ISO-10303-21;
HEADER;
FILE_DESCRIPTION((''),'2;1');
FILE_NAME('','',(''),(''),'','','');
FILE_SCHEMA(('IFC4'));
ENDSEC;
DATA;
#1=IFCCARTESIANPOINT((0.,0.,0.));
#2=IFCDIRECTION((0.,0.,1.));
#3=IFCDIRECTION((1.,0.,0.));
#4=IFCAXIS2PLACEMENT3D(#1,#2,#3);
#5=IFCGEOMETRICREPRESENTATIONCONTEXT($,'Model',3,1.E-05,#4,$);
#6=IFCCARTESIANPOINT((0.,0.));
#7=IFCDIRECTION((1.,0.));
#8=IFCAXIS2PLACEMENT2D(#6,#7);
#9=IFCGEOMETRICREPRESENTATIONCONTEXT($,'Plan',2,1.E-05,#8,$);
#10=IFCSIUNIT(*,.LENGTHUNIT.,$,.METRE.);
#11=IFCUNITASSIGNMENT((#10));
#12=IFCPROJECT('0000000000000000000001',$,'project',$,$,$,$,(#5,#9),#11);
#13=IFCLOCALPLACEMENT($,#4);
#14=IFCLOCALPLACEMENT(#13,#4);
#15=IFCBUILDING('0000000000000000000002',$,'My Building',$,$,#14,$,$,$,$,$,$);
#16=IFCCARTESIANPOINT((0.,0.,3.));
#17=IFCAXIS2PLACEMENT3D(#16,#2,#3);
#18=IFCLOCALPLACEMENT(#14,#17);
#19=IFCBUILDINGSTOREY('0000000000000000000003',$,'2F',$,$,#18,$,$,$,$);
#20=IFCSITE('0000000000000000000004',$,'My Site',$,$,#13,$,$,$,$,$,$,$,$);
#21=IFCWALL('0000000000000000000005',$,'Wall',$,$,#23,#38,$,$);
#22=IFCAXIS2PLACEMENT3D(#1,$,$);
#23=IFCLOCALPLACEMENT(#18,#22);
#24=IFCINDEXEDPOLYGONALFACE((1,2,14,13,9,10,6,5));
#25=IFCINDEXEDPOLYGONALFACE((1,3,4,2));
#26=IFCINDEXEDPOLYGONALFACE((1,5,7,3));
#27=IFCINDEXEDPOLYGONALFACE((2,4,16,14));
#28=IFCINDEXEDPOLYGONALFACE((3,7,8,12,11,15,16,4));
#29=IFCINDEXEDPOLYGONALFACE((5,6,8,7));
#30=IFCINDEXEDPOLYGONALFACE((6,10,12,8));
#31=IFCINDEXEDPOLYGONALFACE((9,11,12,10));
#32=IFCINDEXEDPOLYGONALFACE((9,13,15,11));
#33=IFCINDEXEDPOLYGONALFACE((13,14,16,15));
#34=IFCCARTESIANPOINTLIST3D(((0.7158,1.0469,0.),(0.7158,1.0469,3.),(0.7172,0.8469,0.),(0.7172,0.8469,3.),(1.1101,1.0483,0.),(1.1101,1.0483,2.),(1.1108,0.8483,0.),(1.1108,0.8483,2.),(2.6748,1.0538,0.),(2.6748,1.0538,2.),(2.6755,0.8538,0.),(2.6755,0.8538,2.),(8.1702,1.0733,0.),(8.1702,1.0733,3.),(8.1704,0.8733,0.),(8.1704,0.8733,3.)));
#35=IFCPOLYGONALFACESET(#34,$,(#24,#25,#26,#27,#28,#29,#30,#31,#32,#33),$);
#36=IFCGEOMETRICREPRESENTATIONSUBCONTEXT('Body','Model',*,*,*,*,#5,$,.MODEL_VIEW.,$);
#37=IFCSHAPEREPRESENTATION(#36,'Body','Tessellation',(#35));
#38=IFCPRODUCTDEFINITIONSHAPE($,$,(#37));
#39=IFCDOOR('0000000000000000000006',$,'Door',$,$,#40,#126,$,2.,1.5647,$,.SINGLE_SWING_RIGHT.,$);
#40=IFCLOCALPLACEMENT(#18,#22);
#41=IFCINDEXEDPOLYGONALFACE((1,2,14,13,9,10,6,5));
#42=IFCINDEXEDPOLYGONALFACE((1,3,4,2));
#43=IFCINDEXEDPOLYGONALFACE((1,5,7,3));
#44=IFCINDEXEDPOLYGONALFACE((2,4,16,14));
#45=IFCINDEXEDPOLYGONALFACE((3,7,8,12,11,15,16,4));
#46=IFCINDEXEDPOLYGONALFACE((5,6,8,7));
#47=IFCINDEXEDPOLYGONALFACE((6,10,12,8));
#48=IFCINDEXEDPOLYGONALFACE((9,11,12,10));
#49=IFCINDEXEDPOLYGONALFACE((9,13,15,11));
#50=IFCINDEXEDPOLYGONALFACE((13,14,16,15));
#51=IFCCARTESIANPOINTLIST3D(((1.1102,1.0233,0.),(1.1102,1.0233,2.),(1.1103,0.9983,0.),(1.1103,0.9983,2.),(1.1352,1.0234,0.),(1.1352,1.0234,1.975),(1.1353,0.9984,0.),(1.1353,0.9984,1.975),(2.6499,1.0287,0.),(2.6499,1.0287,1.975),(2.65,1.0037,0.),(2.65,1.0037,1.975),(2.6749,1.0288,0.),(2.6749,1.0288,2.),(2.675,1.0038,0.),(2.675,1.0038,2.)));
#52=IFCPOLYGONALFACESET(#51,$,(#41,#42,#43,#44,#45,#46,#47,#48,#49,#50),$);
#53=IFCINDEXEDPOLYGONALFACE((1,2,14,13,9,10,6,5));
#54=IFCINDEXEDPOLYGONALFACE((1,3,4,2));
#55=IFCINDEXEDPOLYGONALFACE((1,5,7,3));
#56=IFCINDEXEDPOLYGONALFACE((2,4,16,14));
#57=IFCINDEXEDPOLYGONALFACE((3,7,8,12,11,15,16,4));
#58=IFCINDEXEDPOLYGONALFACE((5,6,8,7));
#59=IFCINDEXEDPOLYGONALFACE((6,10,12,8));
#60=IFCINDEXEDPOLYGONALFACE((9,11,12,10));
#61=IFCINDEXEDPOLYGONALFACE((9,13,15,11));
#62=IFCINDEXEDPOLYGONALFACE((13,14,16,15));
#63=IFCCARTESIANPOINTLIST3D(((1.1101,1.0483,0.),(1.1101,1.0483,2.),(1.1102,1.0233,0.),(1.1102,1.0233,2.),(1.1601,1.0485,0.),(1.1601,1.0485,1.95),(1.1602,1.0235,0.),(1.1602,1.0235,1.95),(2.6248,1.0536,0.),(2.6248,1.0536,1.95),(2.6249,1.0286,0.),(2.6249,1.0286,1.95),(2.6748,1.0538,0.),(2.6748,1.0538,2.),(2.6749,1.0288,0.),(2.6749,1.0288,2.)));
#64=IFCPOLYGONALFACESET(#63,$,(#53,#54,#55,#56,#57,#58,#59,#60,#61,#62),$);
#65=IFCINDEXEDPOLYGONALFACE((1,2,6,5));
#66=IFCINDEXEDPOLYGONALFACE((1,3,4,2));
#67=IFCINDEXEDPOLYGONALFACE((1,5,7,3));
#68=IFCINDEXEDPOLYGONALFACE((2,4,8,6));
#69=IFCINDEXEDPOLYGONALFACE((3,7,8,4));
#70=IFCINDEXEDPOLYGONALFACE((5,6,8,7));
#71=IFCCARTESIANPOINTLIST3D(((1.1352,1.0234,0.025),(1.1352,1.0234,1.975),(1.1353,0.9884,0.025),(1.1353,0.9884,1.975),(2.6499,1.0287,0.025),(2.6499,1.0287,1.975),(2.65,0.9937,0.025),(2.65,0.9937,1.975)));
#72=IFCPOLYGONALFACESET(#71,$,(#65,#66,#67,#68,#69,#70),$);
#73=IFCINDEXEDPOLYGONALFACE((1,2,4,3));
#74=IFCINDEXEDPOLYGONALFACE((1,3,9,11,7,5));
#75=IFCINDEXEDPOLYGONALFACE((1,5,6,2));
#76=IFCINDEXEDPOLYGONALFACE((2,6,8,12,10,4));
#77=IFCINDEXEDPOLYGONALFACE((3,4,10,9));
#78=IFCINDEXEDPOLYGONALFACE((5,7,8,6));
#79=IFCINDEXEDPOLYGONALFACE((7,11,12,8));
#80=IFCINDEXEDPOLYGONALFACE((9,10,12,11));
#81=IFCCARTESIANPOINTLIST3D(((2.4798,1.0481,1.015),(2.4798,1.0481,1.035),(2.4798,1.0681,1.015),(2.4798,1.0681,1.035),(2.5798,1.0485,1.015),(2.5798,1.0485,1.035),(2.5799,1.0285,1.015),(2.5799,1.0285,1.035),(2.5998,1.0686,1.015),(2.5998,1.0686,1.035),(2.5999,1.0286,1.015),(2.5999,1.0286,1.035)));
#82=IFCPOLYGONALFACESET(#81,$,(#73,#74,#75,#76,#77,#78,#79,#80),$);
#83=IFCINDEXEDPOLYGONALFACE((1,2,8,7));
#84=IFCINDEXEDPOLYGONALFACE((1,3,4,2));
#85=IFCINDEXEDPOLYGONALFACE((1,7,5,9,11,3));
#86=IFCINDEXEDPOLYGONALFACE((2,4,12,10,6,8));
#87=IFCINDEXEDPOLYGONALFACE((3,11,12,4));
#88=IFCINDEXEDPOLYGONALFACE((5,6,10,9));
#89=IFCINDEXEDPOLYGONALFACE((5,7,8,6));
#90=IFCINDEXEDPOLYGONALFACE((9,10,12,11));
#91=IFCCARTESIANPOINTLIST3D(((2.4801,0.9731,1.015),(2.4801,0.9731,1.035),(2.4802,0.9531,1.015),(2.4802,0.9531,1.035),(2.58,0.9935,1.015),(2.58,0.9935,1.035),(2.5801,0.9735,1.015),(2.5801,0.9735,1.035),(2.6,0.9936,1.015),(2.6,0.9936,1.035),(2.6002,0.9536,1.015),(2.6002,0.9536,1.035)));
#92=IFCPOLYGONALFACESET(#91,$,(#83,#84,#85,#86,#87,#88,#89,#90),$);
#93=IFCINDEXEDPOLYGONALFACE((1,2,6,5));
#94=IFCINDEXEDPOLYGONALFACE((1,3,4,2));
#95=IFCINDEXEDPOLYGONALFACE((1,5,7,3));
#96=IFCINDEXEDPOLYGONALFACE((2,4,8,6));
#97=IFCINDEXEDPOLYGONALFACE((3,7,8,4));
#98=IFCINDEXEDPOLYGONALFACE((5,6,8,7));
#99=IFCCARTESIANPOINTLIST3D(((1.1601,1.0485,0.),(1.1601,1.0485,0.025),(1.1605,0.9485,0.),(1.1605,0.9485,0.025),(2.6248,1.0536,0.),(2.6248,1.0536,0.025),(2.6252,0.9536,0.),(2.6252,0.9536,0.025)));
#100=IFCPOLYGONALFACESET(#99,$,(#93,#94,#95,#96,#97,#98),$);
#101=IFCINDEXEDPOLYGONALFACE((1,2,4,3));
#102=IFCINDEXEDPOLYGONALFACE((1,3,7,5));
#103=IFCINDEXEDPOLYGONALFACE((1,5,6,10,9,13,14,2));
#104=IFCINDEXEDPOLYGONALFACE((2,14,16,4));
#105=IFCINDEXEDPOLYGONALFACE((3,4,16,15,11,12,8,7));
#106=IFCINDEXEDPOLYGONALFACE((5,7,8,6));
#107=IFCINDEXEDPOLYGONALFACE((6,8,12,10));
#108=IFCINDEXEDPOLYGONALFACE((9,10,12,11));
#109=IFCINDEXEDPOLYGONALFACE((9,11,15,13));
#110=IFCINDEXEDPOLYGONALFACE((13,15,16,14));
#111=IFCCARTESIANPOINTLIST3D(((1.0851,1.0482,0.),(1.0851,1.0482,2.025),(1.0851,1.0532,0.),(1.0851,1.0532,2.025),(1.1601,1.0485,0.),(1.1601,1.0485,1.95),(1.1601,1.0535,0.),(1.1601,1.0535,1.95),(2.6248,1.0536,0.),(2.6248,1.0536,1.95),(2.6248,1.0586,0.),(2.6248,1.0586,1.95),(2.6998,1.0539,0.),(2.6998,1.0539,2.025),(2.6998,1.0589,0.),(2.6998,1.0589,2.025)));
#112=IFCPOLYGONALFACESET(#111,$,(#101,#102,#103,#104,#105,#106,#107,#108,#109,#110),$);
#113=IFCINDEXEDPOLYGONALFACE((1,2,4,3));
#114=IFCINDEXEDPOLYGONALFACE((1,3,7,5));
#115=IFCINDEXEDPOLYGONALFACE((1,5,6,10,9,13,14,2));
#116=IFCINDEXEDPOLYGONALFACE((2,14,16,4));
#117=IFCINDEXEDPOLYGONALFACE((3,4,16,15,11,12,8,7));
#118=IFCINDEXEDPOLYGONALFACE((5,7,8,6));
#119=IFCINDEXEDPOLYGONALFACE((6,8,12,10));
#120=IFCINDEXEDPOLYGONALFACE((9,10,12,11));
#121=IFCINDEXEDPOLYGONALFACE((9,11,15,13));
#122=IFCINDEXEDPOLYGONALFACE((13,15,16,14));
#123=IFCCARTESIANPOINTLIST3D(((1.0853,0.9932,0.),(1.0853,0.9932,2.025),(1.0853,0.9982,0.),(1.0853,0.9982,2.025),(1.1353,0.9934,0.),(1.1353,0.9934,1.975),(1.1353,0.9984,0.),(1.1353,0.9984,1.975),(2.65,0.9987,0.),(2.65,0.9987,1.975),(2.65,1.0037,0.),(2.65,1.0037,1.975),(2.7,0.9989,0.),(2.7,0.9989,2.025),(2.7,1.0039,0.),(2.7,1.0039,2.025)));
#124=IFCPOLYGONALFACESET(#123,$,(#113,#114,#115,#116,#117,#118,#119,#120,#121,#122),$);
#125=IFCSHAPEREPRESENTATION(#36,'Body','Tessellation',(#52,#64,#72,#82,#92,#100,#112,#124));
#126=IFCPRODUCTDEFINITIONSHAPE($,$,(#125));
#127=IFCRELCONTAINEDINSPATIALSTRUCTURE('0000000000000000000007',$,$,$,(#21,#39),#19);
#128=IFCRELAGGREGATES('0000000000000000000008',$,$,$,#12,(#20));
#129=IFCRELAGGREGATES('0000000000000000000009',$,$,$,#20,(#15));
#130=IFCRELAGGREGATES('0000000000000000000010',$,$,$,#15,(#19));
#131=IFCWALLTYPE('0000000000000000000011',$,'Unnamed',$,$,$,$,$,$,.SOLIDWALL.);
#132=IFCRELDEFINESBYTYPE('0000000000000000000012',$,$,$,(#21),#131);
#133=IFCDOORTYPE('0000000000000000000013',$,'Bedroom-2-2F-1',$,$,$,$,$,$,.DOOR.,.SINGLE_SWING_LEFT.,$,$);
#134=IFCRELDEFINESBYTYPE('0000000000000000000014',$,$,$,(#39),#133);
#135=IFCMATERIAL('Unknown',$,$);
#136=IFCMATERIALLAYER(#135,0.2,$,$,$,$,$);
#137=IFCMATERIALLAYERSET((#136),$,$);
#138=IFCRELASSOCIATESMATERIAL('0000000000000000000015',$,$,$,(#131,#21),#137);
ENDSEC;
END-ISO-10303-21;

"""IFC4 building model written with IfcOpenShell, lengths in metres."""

from ifc_helpers import new_model, entity, si_unit, frame, origin_with_axes, origin_2d_with_axis, place, context, subcontext, project, spatial, line, indexed_curve, outline, extrude, shape, source, transform, mapped, material, layer, layer_set, layer_usage, type_object, type_shapes, element, fill, save


model = new_model("IFC4")

# Units and contexts
model_context = context("Model", 3, precision=1e-05, world=origin_with_axes())
plan_context = context("Plan", 2, precision=1e-05, world=origin_2d_with_axis())
body_context_1 = subcontext(model_context, "Body", "Model", "MODEL_VIEW")
body_context_2 = subcontext(plan_context, "Body", "Plan", "PLAN_VIEW")
ifc_project = project(units=[si_unit("LENGTHUNIT", "METRE")], contexts=[model_context, plan_context])

# Site, building, storey
site_placement = place(None, origin_with_axes())
site = spatial("IfcSite", under=ifc_project, at=site_placement, Name="My Site")
building_placement = place(site_placement, origin_with_axes())
building = spatial("IfcBuilding", under=site, at=building_placement, Name="My Building")
storey_placement = place(building_placement, frame((0.0, 0.0, 3.0), z_axis=(0.0, 0.0, 1.0), x_axis=(1.0, 0.0, 0.0)))
storey = spatial("IfcBuildingStorey", under=building, at=storey_placement, Name="2F")

# Shared definitions
ifc_material = material(Name="Unknown")

# Shared definitions
ifc_layer_1 = layer(ifc_material, 0.2)
ifc_layer_set_1 = layer_set([ifc_layer_1])
wall_type = type_object("IfcWallType", Name="Unnamed", PredefinedType="SOLIDWALL", material=ifc_layer_set_1)

# Wall, opening, door
ifc_layer_usage_1 = layer_usage(ifc_layer_set_1, "AXIS2", "POSITIVE", 0.0)
wall_1_placement = place(storey_placement, frame((0.5172, 0.8462, 0.0), z_axis=(0.0, 0.0, 1.0), x_axis=(0.999994, 0.003537, 0.0)))
wall_1 = element("IfcWall", 1, at=wall_1_placement, inside=storey, type_object=wall_type, material=ifc_layer_usage_1, Name="Wall", context=body_context_1, shape_type="SweptSolid", body=[
    extrude(outline(indexed_curve([(0.2, 0.0), (0.1993, 0.2), (7.6537, 0.2), (7.6532, 0.0)], segments=[line(1, 2, 3, 4, 1)])), origin_with_axes(), (0.0, 0.0, 1.0), 3.0),
])
shared_shape_1 = source(origin_with_axes(), body_context_1, "Body", "SweptSolid", [
    extrude(outline(indexed_curve([(0.0, 0.0), (1.5647, 0.0), (1.5647, 2.0), (0.0, 2.0)], segments=[line(1, 2, 3, 4, 1)])), frame((0.0, -0.6, 0.0), z_axis=(0.0, -1.0, 0.0), x_axis=(1.0, 0.0, 0.0)), (0.0, 0.0, -1.0), 1.2),
])
opening_1_placement = place(wall_1_placement, frame((2.1583, 0.2, 0.0), z_axis=(0.0, 0.0, 1.0), x_axis=(-1.0, 0.0, 0.0)))
opening_1 = element("IfcOpeningElement", 2, at=opening_1_placement, cuts=wall_1, PredefinedType="OPENING", context=body_context_1, shape_type="MappedRepresentation", body=[
    mapped(shared_shape_1, transform((0.0, 0.0, 0.0), x_axis=(1.0, 0.0, 0.0), y_axis=(0.0, 1.0, 0.0), z_axis=(0.0, 0.0, 1.0), scale=1.0)),
])
door_type_1 = type_object("IfcDoorType", Name="Bedroom-2-2F-1", OperationType="SINGLE_SWING_LEFT", PredefinedType="DOOR")
shared_shape_2 = source(origin_with_axes(), body_context_1, "Body", "SweptSolid", [
    extrude(outline(indexed_curve([(0.0, 0.0), (0.0, 2.0), (1.5647, 2.0), (1.5647, 0.0), (1.5397, 0.0), (1.5397, 1.975), (0.025, 1.975), (0.025, 0.0)], segments=[line(1, 2, 3, 4, 5, 6, 7, 8, 1)])), frame((0.0, 0.025, 0.0), z_axis=(0.0, -1.0, 0.0), x_axis=(1.0, 0.0, 0.0)), (0.0, 0.0, -1.0), 0.025),
    extrude(outline(indexed_curve([(0.0, 0.0), (0.0, 2.0), (1.5647, 2.0), (1.5647, 0.0), (1.5147, 0.0), (1.5147, 1.95), (0.05, 1.95), (0.05, 0.0)], segments=[line(1, 2, 3, 4, 5, 6, 7, 8, 1)])), frame((0.0, 0.0, 0.0), z_axis=(0.0, -1.0, 0.0), x_axis=(1.0, 0.0, 0.0)), (0.0, 0.0, -1.0), 0.025),
    extrude(outline(indexed_curve([(0.0, 0.0), (1.5147, 0.0), (1.5147, 0.035), (0.0, 0.035)], segments=[line(1, 2, 3, 4, 1)])), frame((0.025, 0.025, 0.025), z_axis=(0.0, 0.0, 1.0), x_axis=(1.0, 0.0, 0.0)), (0.0, 0.0, 1.0), 1.95),
    extrude(outline(indexed_curve([(0.0, 0.0), (0.0, -0.04), (0.12, -0.04), (0.12, -0.02), (0.02, -0.02), (0.02, 0.0)], segments=[line(1, 2, 3, 4, 5, 6, 1)])), frame((0.075, 0.025, 1.015), z_axis=(0.0, 0.0, 1.0), x_axis=(1.0, 0.0, 0.0)), (0.0, 0.0, 1.0), 0.02),
    extrude(outline(indexed_curve([(0.0, 0.0), (0.0, 0.04), (0.12, 0.04), (0.12, 0.02), (0.02, 0.02), (0.02, 0.0)], segments=[line(1, 2, 3, 4, 5, 6, 1)])), frame((0.075, 0.06, 1.015), z_axis=(0.0, 0.0, 1.0), x_axis=(1.0, 0.0, 0.0)), (0.0, 0.0, 1.0), 0.02),
    extrude(outline(indexed_curve([(0.0, 0.0), (1.4647, 0.0), (1.4647, 0.1), (0.0, 0.1)], segments=[line(1, 2, 3, 4, 1)])), frame((0.05, 0.0, 0.0), z_axis=(0.0, 0.0, 1.0), x_axis=(1.0, 0.0, 0.0)), (0.0, 0.0, 1.0), 0.025),
    extrude(outline(indexed_curve([(0.0, 0.0), (0.0, 2.025), (1.6147, 2.025), (1.6147, 0.0), (1.5397, 0.0), (1.5397, 1.95), (0.075, 1.95), (0.075, 0.0)], segments=[line(1, 2, 3, 4, 5, 6, 7, 8, 1)])), frame((-0.025, -0.005, 0.0), z_axis=(0.0, -1.0, 0.0), x_axis=(1.0, 0.0, 0.0)), (0.0, 0.0, -1.0), 0.005),
    extrude(outline(indexed_curve([(0.0, 0.0), (0.0, 2.025), (1.6147, 2.025), (1.6147, 0.0), (1.5647, 0.0), (1.5647, 1.975), (0.05, 1.975), (0.05, 0.0)], segments=[line(1, 2, 3, 4, 5, 6, 7, 8, 1)])), frame((-0.025, 0.05, 0.0), z_axis=(0.0, -1.0, 0.0), x_axis=(1.0, 0.0, 0.0)), (0.0, 0.0, -1.0), 0.005),
])
shared_shape_3 = source(origin_with_axes(), body_context_2, "Body", "Curve2D", [
    entity("IfcIndexedPolyCurve", entity("IfcCartesianPointList2D", [[0.0, 0.0], [0.0, 0.05], [0.025, 0.05], [0.025, 0.025], [0.05, 0.025], [0.05, 0.0]]), [entity("IfcLineIndex", [1, 2, 3, 4, 5, 6, 1])]),
    entity("IfcIndexedPolyCurve", entity("IfcCartesianPointList2D", [[1.5647, 0.0], [1.5647, 0.05], [1.5397, 0.05], [1.5397, 0.025], [1.5147, 0.025], [1.5147, 0.0]]), [entity("IfcLineIndex", [1, 2, 3, 4, 5, 6, 1])]),
    entity("IfcTrimmedCurve", entity("IfcEllipse", entity("IfcAxis2Placement2D", entity("IfcCartesianPoint", [1.5047, 0.05]), entity("IfcDirection", [1.0, 0.0])), 1.4797, 1.5147), [entity("IfcCartesianPoint", [1.5047, 1.5647])], [entity("IfcCartesianPoint", [0.025, 0.05])], True, "CARTESIAN"),
    entity("IfcIndexedPolyCurve", entity("IfcCartesianPointList2D", [[1.5397, 0.05], [1.5047, 0.05], [1.5047, 1.5647], [1.5397, 1.5647]]), [entity("IfcLineIndex", [1, 2, 3, 4, 1])]),
])
type_shapes(door_type_1, [shared_shape_2, shared_shape_3])
door_1_placement = place(opening_1_placement, origin_with_axes())
door_1 = element("IfcDoor", 3, at=door_1_placement, inside=storey, type_object=door_type_1, Name="Door", OperationType="SINGLE_SWING_RIGHT", OverallHeight=2.0, OverallWidth=1.5647, shapes=[
    shape(body_context_1, "Body", "MappedRepresentation", [mapped(shared_shape_2, transform((0.0, 0.0, 0.0), x_axis=(1.0, 0.0, 0.0), y_axis=(0.0, 1.0, 0.0), z_axis=(0.0, 0.0, 1.0), scale=1.0))]),
    shape(body_context_2, "Body", "MappedRepresentation", [mapped(shared_shape_3, transform((0.0, 0.0, 0.0), x_axis=(1.0, 0.0, 0.0), y_axis=(0.0, 1.0, 0.0), z_axis=(0.0, 0.0, 1.0), scale=1.0))]),
])
fill(opening_1, door_1)

save(model, "model.ifc")
